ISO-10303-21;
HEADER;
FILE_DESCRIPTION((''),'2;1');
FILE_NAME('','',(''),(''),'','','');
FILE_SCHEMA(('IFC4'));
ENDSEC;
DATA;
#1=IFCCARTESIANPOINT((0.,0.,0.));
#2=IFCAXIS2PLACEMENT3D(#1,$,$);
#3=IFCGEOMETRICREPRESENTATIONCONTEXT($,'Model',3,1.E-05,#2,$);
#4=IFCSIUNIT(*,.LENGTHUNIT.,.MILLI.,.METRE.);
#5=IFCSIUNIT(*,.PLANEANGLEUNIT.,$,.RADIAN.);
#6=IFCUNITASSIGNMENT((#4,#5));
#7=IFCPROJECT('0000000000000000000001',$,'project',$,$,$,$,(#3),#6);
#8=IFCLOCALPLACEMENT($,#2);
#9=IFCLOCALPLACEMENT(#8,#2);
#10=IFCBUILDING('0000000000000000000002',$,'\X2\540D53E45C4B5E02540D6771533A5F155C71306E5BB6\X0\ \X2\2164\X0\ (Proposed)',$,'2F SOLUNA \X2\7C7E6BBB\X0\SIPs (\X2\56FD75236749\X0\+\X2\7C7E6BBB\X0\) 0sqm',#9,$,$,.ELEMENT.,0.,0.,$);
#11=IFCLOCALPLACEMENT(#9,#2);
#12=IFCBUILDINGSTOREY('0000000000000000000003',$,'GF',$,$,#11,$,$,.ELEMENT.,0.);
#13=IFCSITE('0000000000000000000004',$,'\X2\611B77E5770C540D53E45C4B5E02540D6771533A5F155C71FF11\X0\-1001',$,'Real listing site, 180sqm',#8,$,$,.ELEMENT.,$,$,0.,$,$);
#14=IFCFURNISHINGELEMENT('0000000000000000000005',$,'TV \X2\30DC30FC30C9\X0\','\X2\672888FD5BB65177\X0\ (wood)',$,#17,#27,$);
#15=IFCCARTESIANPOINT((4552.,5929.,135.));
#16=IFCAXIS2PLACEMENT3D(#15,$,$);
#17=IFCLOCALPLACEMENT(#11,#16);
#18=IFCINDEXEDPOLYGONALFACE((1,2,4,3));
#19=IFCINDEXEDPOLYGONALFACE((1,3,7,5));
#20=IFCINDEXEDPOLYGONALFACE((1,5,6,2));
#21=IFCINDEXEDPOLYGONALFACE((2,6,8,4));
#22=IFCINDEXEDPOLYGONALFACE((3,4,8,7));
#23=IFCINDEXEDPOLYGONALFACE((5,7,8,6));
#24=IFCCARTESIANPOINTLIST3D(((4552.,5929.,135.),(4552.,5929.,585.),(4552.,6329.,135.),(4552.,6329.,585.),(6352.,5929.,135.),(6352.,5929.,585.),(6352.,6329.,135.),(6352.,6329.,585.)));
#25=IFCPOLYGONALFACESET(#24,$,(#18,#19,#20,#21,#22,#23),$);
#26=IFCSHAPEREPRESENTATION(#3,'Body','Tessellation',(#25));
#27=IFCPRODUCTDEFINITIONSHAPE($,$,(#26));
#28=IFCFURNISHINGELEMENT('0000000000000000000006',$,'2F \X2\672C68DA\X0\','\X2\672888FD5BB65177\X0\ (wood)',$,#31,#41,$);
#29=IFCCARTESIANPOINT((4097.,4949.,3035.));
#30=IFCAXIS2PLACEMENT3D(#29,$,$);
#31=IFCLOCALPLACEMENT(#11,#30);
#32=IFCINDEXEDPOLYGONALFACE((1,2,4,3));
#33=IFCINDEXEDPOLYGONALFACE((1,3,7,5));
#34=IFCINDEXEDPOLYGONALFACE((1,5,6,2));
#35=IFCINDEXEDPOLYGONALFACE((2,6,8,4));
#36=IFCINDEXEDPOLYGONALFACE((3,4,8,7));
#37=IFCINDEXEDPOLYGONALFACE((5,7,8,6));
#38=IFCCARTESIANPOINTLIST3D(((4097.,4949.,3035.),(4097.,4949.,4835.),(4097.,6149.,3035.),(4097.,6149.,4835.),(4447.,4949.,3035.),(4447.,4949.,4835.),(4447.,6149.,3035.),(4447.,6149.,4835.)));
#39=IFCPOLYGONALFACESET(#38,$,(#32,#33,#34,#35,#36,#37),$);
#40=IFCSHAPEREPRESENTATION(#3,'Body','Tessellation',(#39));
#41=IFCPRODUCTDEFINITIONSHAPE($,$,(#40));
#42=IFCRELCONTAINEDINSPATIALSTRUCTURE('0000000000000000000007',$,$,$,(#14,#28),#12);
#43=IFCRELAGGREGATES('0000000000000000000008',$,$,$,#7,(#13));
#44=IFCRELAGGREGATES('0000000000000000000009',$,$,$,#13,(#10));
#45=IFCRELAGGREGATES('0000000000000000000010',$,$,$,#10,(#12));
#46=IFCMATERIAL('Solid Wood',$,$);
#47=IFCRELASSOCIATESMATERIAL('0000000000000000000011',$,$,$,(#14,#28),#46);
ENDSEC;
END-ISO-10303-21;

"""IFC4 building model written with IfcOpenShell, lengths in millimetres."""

from ifc_helpers import new_model, si_unit, frame, frame_2d, origin, place, context, project, spatial, rectangle, extrude, material, element, save


model = new_model("IFC4")

# Units and contexts
model_context = context("Model", 3, precision=1e-05, world=origin())
ifc_project = project(units=[si_unit("LENGTHUNIT", "METRE", prefix="MILLI"), si_unit("PLANEANGLEUNIT", "RADIAN")], contexts=[model_context])

# Site, building, storey
site_placement = place(None, origin())
site = spatial("IfcSite", under=ifc_project, at=site_placement, Name="愛知県名古屋市名東区引山１-1001", ObjectType="Real listing site, 180sqm", CompositionType="ELEMENT", RefElevation=0.0)
building_placement = place(site_placement, origin())
building = spatial("IfcBuilding", under=site, at=building_placement, Name="名古屋市名東区引山の家 Ⅴ (Proposed)", ObjectType="2F SOLUNA 籾殻SIPs (国産杉+籾殻) 0sqm", CompositionType="ELEMENT", ElevationOfRefHeight=0.0, ElevationOfTerrain=0.0)
storey_placement = place(building_placement, origin())
storey = spatial("IfcBuildingStorey", under=building, at=storey_placement, Name="GF", CompositionType="ELEMENT", Elevation=0.0)

# Shared definitions
ifc_material_1 = material(Name="Solid Wood")

# Furnishing elements
furnishing_1_placement = place(storey_placement, frame((4552.0, 5929.0, 135.0)))
element("IfcFurnishingElement", 1, at=furnishing_1_placement, inside=storey, material=ifc_material_1, Name="TV ボード", Description="木製家具 (wood)", context=model_context, shape_type="SweptSolid", body=[
    extrude(rectangle(XDim=1800.0, YDim=400.0, at=frame_2d((900.0, 200.0))), frame((4552.0, 5929.0, 135.0)), (0.0, 0.0, 1.0), 450.0),
])
furnishing_2_placement = place(storey_placement, frame((4097.0, 4949.0, 3035.0)))
element("IfcFurnishingElement", 2, at=furnishing_2_placement, inside=storey, material=ifc_material_1, Name="2F 本棚", Description="木製家具 (wood)", context=model_context, shape_type="SweptSolid", body=[
    extrude(rectangle(XDim=350.0, YDim=1200.0, at=frame_2d((175.0, 600.0))), frame((4097.0, 4949.0, 3035.0)), (0.0, 0.0, 1.0), 1800.0),
])

save(model, "model.ifc")
